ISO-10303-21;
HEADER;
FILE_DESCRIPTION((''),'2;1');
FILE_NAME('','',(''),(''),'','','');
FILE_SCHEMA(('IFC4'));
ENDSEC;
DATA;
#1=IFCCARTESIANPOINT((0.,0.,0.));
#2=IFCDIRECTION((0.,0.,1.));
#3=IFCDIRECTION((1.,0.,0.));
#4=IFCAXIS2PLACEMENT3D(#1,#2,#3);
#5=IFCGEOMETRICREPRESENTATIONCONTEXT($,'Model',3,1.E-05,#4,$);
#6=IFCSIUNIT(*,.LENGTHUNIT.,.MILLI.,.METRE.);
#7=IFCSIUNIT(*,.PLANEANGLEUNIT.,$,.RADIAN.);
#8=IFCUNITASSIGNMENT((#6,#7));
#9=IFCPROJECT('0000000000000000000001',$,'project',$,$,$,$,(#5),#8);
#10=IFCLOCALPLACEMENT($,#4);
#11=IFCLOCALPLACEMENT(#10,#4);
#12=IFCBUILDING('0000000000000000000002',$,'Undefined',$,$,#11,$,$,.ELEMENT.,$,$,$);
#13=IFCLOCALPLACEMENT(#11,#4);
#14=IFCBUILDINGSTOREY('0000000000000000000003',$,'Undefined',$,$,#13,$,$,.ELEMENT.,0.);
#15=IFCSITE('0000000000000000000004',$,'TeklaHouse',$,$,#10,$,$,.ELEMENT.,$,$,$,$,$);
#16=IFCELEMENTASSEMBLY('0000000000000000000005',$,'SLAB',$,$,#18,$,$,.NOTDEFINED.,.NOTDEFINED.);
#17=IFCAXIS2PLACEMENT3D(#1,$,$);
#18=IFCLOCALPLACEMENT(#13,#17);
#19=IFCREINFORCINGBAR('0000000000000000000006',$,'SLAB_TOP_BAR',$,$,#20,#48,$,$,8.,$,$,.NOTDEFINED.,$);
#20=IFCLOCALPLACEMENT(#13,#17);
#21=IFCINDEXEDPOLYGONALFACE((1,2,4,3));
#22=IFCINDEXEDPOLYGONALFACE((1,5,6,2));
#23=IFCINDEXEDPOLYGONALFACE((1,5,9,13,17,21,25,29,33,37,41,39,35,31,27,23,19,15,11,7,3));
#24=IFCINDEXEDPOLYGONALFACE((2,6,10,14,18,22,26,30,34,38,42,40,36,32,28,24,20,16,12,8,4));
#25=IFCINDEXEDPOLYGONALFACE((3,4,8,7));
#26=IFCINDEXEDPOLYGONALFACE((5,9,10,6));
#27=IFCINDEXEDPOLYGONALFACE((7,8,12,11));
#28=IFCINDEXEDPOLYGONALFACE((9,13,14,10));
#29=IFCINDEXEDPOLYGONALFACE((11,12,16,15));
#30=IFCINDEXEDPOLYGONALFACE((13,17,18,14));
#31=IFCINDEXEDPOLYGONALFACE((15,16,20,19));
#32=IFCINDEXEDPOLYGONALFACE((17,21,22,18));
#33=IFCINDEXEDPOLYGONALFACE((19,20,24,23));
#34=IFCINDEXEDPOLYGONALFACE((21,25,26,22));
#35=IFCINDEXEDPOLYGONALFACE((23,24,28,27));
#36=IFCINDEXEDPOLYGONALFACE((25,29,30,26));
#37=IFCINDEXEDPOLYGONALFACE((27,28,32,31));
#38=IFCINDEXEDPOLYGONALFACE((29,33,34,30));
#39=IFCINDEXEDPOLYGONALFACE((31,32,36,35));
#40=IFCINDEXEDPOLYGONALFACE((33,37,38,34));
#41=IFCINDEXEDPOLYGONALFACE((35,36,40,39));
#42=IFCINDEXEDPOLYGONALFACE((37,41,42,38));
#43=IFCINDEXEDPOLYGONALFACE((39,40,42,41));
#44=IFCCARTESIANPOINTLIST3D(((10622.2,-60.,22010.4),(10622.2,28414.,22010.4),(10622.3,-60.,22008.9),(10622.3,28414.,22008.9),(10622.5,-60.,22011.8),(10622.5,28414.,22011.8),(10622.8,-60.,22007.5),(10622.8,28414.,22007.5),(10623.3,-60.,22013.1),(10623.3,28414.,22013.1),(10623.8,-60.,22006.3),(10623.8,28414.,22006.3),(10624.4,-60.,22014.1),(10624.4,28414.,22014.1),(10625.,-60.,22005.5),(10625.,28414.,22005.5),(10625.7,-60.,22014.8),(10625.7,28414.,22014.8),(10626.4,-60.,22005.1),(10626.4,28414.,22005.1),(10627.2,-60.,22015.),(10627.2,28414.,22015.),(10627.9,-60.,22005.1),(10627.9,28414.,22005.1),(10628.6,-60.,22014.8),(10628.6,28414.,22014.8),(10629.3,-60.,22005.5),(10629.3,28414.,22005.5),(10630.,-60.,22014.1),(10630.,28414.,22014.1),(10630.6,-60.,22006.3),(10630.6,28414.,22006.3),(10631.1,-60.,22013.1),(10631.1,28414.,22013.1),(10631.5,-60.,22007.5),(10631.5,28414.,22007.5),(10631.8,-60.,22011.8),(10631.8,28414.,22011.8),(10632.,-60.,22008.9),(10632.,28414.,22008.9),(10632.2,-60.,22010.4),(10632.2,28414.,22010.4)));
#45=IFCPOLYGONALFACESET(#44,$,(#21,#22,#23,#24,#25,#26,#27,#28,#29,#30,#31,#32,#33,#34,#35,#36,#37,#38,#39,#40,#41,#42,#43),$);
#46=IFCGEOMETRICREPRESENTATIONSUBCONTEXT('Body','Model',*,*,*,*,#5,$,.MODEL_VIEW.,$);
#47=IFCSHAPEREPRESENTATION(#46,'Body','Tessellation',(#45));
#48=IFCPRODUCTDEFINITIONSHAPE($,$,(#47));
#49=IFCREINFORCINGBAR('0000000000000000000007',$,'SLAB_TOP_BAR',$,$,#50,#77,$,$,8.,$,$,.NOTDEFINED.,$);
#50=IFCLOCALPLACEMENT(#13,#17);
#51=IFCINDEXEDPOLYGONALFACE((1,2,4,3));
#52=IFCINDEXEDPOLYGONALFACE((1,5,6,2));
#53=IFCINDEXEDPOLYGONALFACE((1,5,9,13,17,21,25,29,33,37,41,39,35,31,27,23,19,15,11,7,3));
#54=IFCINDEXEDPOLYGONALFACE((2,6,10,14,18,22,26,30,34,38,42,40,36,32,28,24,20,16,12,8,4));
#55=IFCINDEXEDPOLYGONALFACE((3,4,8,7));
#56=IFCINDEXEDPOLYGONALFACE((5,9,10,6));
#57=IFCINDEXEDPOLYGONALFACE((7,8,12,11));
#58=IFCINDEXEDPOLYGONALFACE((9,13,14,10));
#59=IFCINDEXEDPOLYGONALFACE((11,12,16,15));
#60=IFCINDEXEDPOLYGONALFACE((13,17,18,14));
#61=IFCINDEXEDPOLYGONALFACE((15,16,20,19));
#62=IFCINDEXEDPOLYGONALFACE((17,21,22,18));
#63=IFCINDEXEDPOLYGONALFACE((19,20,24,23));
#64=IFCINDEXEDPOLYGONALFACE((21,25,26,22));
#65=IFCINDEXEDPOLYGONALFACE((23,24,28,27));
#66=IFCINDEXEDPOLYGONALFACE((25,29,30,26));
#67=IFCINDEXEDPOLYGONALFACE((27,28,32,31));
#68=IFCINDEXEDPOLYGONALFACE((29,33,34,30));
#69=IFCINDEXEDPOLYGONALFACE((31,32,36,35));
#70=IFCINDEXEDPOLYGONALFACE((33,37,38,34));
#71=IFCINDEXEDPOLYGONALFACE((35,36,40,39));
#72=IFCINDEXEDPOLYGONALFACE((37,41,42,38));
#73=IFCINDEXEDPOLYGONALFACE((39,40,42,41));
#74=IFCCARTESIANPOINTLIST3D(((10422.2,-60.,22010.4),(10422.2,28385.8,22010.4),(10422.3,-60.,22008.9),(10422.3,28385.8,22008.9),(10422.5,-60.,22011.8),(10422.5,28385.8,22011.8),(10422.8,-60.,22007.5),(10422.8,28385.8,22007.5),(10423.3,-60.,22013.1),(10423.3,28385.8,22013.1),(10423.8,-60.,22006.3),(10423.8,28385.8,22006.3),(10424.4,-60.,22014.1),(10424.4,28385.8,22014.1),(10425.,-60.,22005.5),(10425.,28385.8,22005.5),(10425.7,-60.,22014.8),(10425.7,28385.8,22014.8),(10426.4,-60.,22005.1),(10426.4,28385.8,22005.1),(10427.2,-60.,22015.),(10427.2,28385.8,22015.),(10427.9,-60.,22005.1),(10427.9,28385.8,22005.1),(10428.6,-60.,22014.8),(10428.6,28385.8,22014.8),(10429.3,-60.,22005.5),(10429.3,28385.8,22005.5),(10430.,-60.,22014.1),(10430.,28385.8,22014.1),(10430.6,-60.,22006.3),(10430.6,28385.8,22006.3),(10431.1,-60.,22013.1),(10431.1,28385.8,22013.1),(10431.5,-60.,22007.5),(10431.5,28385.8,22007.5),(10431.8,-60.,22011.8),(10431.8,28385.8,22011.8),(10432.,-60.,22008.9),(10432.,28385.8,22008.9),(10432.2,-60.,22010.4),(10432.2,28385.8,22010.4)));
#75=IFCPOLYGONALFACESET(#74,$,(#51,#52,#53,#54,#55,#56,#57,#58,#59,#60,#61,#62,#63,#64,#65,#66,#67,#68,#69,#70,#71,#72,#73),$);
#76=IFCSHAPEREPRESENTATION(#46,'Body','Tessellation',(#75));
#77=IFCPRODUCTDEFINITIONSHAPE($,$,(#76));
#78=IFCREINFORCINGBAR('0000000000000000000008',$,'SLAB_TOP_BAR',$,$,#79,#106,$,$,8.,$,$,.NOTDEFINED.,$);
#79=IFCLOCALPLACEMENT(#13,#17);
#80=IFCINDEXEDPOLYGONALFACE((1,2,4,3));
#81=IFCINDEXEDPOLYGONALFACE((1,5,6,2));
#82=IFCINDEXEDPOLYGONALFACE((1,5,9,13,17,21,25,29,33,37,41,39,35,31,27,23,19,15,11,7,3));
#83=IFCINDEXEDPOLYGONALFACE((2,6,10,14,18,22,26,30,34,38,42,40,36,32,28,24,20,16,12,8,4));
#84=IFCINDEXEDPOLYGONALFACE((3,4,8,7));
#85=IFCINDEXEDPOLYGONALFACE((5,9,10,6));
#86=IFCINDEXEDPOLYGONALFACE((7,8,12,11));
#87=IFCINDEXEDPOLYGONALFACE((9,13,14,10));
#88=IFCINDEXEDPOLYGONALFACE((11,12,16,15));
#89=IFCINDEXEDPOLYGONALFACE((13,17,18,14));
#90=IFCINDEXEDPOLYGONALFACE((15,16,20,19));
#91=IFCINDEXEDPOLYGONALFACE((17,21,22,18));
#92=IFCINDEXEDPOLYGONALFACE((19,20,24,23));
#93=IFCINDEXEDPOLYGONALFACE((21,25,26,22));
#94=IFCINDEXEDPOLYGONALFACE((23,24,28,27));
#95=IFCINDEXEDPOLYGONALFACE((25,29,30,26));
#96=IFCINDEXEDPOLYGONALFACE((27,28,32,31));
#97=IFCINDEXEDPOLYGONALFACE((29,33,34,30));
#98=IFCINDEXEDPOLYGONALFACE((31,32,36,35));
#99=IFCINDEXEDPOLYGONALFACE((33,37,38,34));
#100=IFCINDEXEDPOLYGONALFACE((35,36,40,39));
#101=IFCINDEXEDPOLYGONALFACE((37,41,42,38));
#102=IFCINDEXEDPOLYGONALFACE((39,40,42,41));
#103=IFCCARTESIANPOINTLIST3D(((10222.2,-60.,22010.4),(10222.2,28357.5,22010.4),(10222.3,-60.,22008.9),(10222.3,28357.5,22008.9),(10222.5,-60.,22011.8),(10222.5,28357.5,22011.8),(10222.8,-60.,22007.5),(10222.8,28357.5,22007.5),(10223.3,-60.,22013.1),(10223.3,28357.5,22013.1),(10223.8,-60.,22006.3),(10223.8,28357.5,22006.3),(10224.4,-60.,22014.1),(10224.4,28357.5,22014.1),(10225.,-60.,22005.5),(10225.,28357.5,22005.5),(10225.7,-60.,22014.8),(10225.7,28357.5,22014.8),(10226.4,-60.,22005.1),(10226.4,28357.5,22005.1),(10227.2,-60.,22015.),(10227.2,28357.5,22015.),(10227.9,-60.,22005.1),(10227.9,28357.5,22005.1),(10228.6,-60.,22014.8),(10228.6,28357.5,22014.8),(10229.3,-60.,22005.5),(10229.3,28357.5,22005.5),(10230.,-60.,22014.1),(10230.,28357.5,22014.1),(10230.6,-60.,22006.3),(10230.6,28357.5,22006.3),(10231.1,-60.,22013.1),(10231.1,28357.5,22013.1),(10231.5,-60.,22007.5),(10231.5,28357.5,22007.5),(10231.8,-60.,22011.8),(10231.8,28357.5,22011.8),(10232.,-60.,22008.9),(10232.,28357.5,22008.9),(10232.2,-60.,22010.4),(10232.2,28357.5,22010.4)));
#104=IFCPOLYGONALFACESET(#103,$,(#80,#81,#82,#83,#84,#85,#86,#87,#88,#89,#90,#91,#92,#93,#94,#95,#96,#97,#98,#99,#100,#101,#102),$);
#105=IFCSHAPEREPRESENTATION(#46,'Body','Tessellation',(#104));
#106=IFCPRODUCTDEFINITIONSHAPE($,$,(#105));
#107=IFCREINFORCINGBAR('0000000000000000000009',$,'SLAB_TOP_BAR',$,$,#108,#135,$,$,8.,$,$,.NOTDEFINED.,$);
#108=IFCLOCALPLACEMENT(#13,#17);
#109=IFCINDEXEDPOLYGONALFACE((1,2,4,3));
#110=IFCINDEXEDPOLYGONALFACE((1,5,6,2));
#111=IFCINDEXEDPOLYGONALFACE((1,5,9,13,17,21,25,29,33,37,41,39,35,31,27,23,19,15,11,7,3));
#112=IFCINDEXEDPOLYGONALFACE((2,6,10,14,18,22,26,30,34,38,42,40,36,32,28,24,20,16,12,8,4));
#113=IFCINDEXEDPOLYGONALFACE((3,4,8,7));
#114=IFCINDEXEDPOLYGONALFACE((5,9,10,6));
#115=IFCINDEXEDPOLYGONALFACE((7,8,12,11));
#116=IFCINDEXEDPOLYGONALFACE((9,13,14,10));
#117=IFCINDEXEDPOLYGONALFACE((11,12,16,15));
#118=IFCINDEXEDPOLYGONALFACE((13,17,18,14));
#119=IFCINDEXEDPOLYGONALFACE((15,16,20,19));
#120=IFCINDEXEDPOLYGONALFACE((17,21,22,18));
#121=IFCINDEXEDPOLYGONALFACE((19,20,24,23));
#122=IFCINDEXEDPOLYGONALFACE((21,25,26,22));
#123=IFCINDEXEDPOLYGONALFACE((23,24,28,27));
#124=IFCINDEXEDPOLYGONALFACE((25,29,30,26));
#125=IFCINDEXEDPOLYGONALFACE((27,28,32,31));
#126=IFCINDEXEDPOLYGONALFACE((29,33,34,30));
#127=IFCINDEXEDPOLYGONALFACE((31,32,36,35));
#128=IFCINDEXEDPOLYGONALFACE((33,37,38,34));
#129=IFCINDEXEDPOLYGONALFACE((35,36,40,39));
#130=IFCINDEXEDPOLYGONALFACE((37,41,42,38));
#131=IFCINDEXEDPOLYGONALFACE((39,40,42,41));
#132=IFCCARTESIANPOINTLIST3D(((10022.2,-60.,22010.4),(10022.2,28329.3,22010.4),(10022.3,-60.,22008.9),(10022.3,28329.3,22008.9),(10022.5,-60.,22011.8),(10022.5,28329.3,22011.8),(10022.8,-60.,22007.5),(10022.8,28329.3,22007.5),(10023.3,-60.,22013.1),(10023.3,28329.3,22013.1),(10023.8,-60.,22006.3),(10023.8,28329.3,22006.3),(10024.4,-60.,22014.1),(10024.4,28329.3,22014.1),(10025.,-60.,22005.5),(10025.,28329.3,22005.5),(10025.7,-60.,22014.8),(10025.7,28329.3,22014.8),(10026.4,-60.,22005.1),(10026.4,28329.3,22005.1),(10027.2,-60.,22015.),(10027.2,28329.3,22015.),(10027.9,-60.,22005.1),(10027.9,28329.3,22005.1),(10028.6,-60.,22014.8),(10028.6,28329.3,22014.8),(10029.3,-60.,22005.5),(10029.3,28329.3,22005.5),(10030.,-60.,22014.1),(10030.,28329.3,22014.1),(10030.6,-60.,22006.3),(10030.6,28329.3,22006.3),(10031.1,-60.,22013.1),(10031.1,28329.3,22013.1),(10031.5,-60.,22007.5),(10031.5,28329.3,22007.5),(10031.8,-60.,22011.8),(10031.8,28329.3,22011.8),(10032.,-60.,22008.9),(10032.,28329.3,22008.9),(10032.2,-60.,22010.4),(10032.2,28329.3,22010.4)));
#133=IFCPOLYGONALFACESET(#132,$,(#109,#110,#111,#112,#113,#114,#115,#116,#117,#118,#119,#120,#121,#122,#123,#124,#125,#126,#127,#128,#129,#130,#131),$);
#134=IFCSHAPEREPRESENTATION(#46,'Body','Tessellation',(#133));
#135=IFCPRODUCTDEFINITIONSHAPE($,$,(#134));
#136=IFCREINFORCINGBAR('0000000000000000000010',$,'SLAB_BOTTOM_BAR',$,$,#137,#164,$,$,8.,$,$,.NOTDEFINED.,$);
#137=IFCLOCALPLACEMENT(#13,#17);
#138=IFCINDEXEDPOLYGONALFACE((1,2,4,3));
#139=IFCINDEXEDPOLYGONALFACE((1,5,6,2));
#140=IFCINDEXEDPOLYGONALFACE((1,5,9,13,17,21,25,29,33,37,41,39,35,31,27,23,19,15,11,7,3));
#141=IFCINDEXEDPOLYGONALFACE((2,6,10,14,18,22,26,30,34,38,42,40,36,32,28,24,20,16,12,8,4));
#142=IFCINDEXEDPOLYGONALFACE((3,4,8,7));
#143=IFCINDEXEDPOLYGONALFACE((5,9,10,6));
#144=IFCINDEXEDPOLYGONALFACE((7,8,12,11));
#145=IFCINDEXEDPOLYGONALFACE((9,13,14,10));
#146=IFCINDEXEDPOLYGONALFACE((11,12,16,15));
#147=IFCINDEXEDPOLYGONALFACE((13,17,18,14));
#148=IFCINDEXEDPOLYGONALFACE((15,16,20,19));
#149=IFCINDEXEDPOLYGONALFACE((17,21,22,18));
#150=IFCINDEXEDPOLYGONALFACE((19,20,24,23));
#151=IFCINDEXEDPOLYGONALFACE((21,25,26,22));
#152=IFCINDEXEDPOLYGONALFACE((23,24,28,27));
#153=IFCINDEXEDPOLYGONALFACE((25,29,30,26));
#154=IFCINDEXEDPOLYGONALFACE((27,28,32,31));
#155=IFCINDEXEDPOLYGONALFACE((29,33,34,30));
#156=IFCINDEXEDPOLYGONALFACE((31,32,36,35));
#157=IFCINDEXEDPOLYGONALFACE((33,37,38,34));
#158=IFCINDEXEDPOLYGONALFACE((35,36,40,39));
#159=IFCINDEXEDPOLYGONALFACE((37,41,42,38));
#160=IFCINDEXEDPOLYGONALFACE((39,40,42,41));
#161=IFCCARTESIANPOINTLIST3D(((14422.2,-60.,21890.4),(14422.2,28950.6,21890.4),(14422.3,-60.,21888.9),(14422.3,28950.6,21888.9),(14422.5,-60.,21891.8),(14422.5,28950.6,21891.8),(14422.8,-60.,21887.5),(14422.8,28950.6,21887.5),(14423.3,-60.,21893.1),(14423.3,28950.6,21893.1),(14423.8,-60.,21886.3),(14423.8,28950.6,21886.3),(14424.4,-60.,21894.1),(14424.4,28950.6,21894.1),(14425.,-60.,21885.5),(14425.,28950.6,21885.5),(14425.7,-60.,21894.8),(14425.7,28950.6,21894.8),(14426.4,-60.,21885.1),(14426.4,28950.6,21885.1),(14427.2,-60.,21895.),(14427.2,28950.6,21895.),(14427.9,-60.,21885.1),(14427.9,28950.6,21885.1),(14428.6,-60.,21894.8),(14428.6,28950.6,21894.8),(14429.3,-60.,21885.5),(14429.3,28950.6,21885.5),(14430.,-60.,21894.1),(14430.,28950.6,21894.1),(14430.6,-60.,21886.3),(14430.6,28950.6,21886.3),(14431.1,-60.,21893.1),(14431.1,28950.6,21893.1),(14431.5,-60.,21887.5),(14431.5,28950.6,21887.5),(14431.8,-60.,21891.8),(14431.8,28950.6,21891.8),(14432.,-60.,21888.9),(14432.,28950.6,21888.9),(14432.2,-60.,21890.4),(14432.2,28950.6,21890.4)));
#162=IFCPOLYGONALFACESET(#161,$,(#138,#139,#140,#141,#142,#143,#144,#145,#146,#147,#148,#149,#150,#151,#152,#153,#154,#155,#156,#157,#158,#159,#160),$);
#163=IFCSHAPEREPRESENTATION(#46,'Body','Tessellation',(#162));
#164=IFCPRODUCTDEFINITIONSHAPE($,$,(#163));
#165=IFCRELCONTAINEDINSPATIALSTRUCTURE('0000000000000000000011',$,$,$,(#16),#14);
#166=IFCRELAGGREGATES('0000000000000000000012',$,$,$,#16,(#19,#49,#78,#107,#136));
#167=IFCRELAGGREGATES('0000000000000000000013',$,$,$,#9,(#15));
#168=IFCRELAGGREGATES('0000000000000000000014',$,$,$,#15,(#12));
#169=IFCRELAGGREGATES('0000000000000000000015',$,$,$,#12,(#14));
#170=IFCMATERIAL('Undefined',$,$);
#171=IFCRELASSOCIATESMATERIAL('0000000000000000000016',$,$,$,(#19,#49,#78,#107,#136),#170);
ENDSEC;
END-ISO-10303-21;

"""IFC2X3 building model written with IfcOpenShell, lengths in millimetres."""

from ifc_helpers import new_model, entity, si_unit, frame, origin_with_axes, place, context, subcontext, project, spatial, source, transform, mapped, material, element, aggregate, save


model = new_model("IFC2X3")

# Units and contexts
model_context = context("Model", 3, precision=1e-05, world=origin_with_axes())
body_context = subcontext(model_context, "Body", "Model", "MODEL_VIEW")
ifc_project = project(units=[si_unit("LENGTHUNIT", "METRE", prefix="MILLI"), si_unit("PLANEANGLEUNIT", "RADIAN")], contexts=[model_context])

# Site, building, storey
site_placement = place(None, origin_with_axes())
site = spatial("IfcSite", under=ifc_project, at=site_placement, Name="TeklaHouse", CompositionType="ELEMENT")
building_placement = place(site_placement, origin_with_axes())
building = spatial("IfcBuilding", under=site, at=building_placement, Name="Undefined", CompositionType="ELEMENT")
storey_placement = place(building_placement, origin_with_axes())
storey = spatial("IfcBuildingStorey", under=building, at=storey_placement, Name="Undefined", CompositionType="ELEMENT", Elevation=0.0)

# Shared definitions
ifc_material_1 = material(Name="Undefined")

# Element assembly, reinforcing bars
assembly_1_placement = place(storey_placement, origin_with_axes())
assembly_1 = element("IfcElementAssembly", 1, at=assembly_1_placement, inside=storey, Name="SLAB", AssemblyPlace="NOTDEFINED", PredefinedType="NOTDEFINED")
shared_shape_1 = source(origin_with_axes(), body_context, "Body", "AdvancedSweptSolid", [
    entity("IfcSweptDiskSolid", entity("IfcTrimmedCurve", entity("IfcLine", entity("IfcCartesianPoint", [0.0, 0.0, 0.0]), entity("IfcVector", entity("IfcDirection", [1.0, 0.0, 0.0]), 1.0)), [entity("IfcParameterValue", 0.0)], [entity("IfcParameterValue", 28474.005366)], True, "PARAMETER"), 5.0, None, 0.0, 28474.0),
])
reinforcing_bar_1_placement = place(assembly_1_placement, frame((10627.2, -60.0, 22010.0), z_axis=(0.0, 0.0, 1.0), x_axis=(0.0, 1.0, 0.0)))
reinforcing_bar_1 = element("IfcReinforcingBar", 2, at=reinforcing_bar_1_placement, material=ifc_material_1, Name="SLAB_TOP_BAR", BarRole="NOTDEFINED", NominalDiameter=8.0, context=body_context, shape_type="MappedRepresentation", body=[
    mapped(shared_shape_1, transform((0.0, 0.0, 0.0))),
])
shared_shape_2 = source(origin_with_axes(), body_context, "Body", "AdvancedSweptSolid", [
    entity("IfcSweptDiskSolid", entity("IfcTrimmedCurve", entity("IfcLine", entity("IfcCartesianPoint", [0.0, 0.0, 0.0]), entity("IfcVector", entity("IfcDirection", [1.0, 0.0, 0.0]), 1.0)), [entity("IfcParameterValue", 0.0)], [entity("IfcParameterValue", 28445.763256)], True, "PARAMETER"), 5.0, None, 0.0, 28445.8),
])
reinforcing_bar_2_placement = place(assembly_1_placement, frame((10427.2, -60.0, 22010.0), z_axis=(0.0, 0.0, 1.0), x_axis=(0.0, 1.0, 0.0)))
reinforcing_bar_2 = element("IfcReinforcingBar", 3, at=reinforcing_bar_2_placement, material=ifc_material_1, Name="SLAB_TOP_BAR", BarRole="NOTDEFINED", NominalDiameter=8.0, context=body_context, shape_type="MappedRepresentation", body=[
    mapped(shared_shape_2, transform((0.0, 0.0, 0.0))),
])
shared_shape_3 = source(origin_with_axes(), body_context, "Body", "AdvancedSweptSolid", [
    entity("IfcSweptDiskSolid", entity("IfcTrimmedCurve", entity("IfcLine", entity("IfcCartesianPoint", [0.0, 0.0, 0.0]), entity("IfcVector", entity("IfcDirection", [1.0, 0.0, 0.0]), 1.0)), [entity("IfcParameterValue", 0.0)], [entity("IfcParameterValue", 28417.521145)], True, "PARAMETER"), 5.0, None, 0.0, 28417.5),
])
reinforcing_bar_3_placement = place(assembly_1_placement, frame((10227.2, -60.0, 22010.0), z_axis=(0.0, 0.0, 1.0), x_axis=(0.0, 1.0, 0.0)))
reinforcing_bar_3 = element("IfcReinforcingBar", 4, at=reinforcing_bar_3_placement, material=ifc_material_1, Name="SLAB_TOP_BAR", BarRole="NOTDEFINED", NominalDiameter=8.0, context=body_context, shape_type="MappedRepresentation", body=[
    mapped(shared_shape_3, transform((0.0, 0.0, 0.0))),
])
shared_shape_4 = source(origin_with_axes(), body_context, "Body", "AdvancedSweptSolid", [
    entity("IfcSweptDiskSolid", entity("IfcTrimmedCurve", entity("IfcLine", entity("IfcCartesianPoint", [0.0, 0.0, 0.0]), entity("IfcVector", entity("IfcDirection", [1.0, 0.0, 0.0]), 1.0)), [entity("IfcParameterValue", 0.0)], [entity("IfcParameterValue", 28389.279034)], True, "PARAMETER"), 5.0, None, 0.0, 28389.3),
])
reinforcing_bar_4_placement = place(assembly_1_placement, frame((10027.2, -60.0, 22010.0), z_axis=(0.0, 0.0, 1.0), x_axis=(0.0, 1.0, 0.0)))
reinforcing_bar_4 = element("IfcReinforcingBar", 5, at=reinforcing_bar_4_placement, material=ifc_material_1, Name="SLAB_TOP_BAR", BarRole="NOTDEFINED", NominalDiameter=8.0, context=body_context, shape_type="MappedRepresentation", body=[
    mapped(shared_shape_4, transform((0.0, 0.0, 0.0))),
])
shared_shape_5 = source(origin_with_axes(), body_context, "Body", "AdvancedSweptSolid", [
    entity("IfcSweptDiskSolid", entity("IfcTrimmedCurve", entity("IfcLine", entity("IfcCartesianPoint", [0.0, 0.0, 0.0]), entity("IfcVector", entity("IfcDirection", [1.0, 0.0, 0.0]), 1.0)), [entity("IfcParameterValue", 0.0)], [entity("IfcParameterValue", 29010.60547)], True, "PARAMETER"), 5.0, None, 0.0, 29010.6),
])
reinforcing_bar_5_placement = place(assembly_1_placement, frame((14427.2, -60.0, 21890.0), z_axis=(0.0, 0.0, 1.0), x_axis=(0.0, 1.0, 0.0)))
reinforcing_bar_5 = element("IfcReinforcingBar", 6, at=reinforcing_bar_5_placement, material=ifc_material_1, Name="SLAB_BOTTOM_BAR", BarRole="NOTDEFINED", NominalDiameter=8.0, context=body_context, shape_type="MappedRepresentation", body=[
    mapped(shared_shape_5, transform((0.0, 0.0, 0.0))),
])
aggregate(assembly_1, [reinforcing_bar_1, reinforcing_bar_2, reinforcing_bar_3, reinforcing_bar_4, reinforcing_bar_5])

save(model, "model.ifc")
